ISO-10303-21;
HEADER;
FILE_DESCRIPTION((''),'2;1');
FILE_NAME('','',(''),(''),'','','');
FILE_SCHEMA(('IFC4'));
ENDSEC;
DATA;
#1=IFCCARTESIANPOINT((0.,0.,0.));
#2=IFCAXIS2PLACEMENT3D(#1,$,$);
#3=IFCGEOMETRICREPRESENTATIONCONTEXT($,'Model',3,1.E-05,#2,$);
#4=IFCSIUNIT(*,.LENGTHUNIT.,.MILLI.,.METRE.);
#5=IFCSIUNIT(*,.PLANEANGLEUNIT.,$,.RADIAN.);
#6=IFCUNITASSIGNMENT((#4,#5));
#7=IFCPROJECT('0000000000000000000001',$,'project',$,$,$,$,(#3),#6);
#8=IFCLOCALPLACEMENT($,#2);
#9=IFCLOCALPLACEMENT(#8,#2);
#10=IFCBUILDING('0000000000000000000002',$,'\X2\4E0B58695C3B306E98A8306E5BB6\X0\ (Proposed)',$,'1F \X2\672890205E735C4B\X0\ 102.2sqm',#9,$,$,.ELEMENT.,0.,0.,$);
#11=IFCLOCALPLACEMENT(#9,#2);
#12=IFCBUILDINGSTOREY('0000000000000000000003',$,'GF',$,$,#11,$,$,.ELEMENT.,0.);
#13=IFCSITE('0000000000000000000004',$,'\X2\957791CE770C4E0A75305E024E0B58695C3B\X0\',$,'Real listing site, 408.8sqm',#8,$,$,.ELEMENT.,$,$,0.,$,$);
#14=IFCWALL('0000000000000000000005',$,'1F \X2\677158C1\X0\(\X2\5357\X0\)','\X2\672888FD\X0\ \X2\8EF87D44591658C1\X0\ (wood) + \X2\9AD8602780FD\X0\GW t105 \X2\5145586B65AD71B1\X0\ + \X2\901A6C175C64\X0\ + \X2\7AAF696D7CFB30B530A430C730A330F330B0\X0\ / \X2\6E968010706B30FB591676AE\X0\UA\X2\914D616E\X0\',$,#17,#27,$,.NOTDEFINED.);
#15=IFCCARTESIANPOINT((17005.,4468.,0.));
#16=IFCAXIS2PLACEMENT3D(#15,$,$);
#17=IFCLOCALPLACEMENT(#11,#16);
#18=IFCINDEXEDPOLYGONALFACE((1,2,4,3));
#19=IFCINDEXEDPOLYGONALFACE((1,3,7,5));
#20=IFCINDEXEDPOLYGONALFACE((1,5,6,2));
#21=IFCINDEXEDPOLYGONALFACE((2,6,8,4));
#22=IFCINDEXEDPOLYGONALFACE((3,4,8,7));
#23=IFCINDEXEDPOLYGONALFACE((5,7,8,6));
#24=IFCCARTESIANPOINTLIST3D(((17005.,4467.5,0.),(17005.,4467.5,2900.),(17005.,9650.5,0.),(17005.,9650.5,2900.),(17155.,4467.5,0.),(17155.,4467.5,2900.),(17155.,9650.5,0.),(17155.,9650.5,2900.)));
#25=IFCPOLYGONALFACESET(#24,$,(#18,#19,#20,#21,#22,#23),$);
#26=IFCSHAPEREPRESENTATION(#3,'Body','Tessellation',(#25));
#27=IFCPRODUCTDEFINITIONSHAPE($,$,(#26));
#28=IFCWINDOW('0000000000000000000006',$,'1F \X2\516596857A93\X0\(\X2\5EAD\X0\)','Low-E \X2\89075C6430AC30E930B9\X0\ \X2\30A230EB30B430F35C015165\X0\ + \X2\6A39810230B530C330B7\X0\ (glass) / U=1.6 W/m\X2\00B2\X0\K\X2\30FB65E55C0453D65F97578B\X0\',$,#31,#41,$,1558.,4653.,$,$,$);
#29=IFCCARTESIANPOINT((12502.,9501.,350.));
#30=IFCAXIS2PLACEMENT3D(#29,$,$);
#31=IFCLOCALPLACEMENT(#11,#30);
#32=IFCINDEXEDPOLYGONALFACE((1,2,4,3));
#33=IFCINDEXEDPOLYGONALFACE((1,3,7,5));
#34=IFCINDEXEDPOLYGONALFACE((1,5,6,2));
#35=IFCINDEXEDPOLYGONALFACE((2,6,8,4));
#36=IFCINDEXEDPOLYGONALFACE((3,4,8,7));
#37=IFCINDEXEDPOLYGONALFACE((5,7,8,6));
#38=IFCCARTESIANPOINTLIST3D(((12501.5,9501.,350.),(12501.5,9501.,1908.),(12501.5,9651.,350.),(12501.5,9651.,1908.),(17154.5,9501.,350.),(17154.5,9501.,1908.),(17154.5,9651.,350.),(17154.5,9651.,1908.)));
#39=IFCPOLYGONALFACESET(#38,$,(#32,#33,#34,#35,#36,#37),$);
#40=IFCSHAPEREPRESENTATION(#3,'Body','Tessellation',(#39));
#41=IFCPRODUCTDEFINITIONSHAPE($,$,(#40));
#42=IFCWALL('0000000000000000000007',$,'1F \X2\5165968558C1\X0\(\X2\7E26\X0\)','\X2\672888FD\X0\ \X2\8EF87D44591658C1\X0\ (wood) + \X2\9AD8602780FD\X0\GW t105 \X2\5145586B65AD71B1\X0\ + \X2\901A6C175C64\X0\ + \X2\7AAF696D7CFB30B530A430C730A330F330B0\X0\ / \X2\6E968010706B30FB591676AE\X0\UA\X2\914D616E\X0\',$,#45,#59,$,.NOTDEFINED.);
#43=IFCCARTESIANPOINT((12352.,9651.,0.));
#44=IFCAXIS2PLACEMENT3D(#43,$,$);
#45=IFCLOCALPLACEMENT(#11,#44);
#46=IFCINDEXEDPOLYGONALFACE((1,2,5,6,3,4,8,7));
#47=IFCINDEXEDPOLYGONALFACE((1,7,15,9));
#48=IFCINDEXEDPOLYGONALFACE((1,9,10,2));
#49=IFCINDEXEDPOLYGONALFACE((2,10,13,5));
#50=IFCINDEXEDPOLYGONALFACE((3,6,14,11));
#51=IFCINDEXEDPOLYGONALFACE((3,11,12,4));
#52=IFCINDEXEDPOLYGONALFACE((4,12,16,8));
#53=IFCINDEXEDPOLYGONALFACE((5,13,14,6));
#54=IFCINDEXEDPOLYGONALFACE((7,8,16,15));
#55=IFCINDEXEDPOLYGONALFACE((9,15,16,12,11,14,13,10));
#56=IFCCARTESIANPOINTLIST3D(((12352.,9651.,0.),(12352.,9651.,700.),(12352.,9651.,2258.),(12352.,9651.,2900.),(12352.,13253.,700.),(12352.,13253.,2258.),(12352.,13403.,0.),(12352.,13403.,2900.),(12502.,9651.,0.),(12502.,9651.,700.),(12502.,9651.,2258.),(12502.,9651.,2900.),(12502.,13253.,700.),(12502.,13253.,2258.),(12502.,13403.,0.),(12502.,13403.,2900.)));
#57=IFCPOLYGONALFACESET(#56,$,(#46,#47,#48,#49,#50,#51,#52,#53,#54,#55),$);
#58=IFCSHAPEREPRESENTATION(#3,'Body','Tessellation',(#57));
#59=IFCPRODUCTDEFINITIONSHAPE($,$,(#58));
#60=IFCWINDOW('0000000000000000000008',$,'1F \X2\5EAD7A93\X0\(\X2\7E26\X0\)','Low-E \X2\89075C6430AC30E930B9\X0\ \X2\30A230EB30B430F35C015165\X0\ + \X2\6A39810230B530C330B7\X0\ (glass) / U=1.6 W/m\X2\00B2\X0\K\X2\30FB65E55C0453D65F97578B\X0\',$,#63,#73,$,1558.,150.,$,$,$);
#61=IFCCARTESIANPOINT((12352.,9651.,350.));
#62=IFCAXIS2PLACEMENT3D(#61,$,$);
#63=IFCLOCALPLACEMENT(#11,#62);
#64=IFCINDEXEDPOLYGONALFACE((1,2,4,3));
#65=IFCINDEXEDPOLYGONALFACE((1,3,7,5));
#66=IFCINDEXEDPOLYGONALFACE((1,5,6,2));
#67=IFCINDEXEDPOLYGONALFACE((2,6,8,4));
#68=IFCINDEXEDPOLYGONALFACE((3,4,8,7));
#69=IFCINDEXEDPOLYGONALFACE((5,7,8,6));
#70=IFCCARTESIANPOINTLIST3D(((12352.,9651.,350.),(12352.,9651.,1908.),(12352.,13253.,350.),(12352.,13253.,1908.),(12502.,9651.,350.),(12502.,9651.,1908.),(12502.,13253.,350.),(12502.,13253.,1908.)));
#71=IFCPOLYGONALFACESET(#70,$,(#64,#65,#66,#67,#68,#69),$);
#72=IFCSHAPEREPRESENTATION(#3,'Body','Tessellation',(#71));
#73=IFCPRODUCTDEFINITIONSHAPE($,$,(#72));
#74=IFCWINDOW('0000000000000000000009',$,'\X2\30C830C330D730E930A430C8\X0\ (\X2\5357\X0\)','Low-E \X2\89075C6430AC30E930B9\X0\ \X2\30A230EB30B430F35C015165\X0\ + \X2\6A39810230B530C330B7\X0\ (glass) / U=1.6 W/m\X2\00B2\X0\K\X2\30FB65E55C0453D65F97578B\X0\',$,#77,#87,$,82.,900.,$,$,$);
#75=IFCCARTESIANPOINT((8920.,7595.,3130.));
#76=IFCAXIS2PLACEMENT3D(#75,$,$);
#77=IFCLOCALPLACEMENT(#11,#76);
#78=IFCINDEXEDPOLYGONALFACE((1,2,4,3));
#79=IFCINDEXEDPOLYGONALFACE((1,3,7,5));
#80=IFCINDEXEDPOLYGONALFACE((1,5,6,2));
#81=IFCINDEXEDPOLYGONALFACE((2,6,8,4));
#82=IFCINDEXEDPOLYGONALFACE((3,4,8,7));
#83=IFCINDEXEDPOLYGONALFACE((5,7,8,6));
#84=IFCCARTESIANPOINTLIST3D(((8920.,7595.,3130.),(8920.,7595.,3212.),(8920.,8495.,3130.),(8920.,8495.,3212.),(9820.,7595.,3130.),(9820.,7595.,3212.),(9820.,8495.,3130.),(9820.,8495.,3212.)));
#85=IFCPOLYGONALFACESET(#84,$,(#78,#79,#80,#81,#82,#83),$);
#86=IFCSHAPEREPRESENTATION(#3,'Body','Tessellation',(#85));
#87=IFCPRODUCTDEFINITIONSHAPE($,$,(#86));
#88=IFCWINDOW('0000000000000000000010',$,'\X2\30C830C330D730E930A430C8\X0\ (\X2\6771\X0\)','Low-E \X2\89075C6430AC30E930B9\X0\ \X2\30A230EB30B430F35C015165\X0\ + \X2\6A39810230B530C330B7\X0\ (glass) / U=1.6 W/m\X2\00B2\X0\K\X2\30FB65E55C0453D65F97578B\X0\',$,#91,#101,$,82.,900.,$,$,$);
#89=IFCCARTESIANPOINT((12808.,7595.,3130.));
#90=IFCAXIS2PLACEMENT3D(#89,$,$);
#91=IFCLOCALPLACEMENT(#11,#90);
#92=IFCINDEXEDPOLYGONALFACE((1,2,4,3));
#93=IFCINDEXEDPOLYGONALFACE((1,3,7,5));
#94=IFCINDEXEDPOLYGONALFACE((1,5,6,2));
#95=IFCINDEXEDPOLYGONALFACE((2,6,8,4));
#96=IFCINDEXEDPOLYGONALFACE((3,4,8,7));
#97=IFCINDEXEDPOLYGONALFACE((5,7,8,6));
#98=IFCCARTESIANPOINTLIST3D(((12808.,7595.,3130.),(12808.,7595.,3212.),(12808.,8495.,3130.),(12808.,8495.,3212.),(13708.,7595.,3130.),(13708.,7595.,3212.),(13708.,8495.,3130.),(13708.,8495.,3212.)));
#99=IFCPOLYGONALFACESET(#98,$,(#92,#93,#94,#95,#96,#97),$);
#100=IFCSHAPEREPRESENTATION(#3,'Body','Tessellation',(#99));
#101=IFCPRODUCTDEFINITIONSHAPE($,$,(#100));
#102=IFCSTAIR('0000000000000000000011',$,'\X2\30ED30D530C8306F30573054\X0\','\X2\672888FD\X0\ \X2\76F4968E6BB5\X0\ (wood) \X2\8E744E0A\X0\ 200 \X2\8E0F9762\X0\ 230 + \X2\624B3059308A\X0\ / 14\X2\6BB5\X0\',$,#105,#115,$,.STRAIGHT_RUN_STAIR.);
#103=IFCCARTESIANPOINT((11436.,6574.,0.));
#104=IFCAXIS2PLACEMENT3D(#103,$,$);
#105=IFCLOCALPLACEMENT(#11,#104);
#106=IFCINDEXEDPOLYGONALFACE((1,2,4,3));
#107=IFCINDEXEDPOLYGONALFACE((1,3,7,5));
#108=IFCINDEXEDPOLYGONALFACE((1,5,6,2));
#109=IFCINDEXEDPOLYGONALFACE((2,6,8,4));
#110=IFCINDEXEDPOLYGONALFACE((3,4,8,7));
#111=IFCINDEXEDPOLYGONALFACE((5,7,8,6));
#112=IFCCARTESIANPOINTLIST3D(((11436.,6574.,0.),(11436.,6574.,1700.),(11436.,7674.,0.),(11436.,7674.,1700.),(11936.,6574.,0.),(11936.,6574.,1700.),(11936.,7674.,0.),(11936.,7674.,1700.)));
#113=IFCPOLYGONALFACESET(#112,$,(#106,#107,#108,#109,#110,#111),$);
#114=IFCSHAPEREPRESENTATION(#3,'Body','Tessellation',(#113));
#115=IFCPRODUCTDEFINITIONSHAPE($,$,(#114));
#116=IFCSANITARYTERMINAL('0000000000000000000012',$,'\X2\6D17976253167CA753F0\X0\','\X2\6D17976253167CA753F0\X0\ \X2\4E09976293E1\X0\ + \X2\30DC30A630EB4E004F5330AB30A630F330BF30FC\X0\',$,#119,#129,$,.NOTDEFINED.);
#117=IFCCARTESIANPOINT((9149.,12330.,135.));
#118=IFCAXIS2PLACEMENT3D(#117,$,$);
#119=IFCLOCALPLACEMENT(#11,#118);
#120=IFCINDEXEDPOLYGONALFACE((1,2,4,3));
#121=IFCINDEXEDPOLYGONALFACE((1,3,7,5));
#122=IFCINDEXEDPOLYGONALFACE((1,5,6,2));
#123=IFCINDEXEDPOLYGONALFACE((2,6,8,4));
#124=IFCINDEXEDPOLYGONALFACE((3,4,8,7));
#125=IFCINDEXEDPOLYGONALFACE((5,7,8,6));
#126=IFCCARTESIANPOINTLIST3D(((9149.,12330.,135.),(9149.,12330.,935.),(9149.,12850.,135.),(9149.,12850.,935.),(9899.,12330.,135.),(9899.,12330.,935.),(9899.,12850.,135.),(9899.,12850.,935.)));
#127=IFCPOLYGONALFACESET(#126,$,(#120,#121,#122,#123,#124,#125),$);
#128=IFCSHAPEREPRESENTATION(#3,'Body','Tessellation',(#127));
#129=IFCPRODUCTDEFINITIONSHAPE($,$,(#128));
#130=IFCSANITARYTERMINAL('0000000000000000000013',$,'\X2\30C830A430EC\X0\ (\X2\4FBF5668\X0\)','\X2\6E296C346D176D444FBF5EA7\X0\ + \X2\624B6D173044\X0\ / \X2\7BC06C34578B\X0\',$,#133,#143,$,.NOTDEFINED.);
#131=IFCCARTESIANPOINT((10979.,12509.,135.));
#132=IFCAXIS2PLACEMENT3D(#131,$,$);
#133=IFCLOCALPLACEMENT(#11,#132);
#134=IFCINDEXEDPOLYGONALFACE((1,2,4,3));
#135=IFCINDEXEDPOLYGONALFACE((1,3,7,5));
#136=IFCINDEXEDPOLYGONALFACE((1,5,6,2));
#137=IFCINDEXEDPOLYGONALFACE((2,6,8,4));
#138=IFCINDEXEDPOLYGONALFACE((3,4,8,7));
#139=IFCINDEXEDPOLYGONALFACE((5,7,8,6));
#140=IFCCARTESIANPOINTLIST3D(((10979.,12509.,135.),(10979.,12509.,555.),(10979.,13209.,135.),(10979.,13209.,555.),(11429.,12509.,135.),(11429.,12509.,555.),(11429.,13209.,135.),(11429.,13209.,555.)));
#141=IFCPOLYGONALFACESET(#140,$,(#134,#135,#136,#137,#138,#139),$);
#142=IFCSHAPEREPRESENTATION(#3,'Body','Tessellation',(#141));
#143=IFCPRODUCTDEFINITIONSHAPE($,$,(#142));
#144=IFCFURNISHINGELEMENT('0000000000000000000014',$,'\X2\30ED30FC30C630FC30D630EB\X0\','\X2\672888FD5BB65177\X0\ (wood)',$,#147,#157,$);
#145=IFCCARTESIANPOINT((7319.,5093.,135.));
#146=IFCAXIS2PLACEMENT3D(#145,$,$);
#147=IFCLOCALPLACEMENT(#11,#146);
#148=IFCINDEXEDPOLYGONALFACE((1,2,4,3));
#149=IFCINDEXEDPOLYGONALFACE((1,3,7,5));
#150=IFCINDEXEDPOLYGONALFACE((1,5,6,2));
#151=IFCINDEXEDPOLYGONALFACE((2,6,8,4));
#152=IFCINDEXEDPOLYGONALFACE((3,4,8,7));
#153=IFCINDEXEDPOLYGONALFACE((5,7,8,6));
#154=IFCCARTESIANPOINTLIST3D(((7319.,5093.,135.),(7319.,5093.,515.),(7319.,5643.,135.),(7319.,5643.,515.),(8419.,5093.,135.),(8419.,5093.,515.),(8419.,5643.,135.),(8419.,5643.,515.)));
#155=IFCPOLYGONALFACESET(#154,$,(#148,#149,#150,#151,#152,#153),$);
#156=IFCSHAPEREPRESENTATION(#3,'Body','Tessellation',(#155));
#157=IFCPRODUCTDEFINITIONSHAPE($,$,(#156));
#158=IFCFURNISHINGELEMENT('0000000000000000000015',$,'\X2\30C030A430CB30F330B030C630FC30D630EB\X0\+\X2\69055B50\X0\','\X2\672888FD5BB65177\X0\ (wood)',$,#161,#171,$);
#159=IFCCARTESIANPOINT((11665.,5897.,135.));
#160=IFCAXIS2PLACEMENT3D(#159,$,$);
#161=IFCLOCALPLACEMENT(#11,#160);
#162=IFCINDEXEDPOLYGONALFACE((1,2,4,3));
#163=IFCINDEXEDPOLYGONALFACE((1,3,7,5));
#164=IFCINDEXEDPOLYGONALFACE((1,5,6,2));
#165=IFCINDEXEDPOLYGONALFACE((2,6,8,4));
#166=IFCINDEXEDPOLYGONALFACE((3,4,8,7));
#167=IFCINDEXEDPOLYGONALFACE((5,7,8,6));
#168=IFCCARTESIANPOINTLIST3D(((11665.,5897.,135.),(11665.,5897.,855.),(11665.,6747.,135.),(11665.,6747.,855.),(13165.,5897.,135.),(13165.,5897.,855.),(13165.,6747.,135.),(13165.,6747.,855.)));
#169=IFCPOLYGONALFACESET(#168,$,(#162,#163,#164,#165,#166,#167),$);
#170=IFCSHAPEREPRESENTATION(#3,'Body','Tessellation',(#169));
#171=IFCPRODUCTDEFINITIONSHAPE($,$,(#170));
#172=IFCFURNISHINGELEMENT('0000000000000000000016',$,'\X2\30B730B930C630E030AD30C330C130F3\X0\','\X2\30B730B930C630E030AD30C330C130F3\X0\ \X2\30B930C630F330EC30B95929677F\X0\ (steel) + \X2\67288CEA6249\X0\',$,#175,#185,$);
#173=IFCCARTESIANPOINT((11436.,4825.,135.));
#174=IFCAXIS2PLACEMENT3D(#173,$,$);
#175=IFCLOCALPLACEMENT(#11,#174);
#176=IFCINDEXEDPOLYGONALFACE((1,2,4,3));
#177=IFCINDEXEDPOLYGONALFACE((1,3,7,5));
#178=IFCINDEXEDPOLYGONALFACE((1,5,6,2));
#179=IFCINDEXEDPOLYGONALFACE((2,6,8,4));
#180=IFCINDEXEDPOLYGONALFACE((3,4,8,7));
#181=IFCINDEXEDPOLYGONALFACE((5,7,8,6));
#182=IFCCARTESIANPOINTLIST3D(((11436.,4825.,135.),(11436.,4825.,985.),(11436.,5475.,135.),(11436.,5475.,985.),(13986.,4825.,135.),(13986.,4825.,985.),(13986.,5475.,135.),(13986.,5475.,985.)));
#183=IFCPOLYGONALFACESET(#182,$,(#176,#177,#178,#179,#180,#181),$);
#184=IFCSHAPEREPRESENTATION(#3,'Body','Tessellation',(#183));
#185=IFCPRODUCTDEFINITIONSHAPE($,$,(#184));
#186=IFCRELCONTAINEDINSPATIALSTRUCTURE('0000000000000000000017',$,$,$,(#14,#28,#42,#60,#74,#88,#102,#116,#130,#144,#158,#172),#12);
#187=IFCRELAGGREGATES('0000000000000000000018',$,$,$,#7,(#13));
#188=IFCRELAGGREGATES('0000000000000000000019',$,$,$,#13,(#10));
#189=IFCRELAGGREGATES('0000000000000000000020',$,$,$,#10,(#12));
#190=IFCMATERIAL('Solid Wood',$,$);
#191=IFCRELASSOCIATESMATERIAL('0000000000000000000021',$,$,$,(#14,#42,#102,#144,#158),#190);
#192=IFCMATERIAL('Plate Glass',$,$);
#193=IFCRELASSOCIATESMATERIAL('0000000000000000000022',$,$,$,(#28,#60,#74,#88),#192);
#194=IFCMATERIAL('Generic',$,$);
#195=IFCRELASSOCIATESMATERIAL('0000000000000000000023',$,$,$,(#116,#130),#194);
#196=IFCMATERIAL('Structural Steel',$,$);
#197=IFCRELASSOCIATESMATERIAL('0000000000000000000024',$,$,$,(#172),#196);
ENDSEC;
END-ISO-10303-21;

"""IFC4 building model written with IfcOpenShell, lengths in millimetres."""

from ifc_helpers import new_model, si_unit, frame, frame_2d, origin, place, context, project, spatial, rectangle, extrude, material, element, fill, save


model = new_model("IFC4")

# Units and contexts
model_context = context("Model", 3, precision=1e-05, world=origin())
ifc_project = project(units=[si_unit("LENGTHUNIT", "METRE", prefix="MILLI"), si_unit("PLANEANGLEUNIT", "RADIAN")], contexts=[model_context])

# Site, building, storey
site_placement = place(None, origin())
site = spatial("IfcSite", under=ifc_project, at=site_placement, Name="長野県上田市下塩尻", ObjectType="Real listing site, 408.8sqm", CompositionType="ELEMENT", RefElevation=0.0)
building_placement = place(site_placement, origin())
building = spatial("IfcBuilding", under=site, at=building_placement, Name="下塩尻の風の家 (Proposed)", ObjectType="1F 木造平屋 102.2sqm", CompositionType="ELEMENT", ElevationOfRefHeight=0.0, ElevationOfTerrain=0.0)
storey_placement = place(building_placement, origin())
storey = spatial("IfcBuildingStorey", under=building, at=storey_placement, Name="GF", CompositionType="ELEMENT", Elevation=0.0)

# Shared definitions
ifc_material_1 = material(Name="Solid Wood")

# Wall, opening, window
wall_1_placement = place(storey_placement, frame((17005.0, 4468.0, 0.0)))
wall_1 = element("IfcWall", 1, at=wall_1_placement, inside=storey, material=ifc_material_1, Name="1F 東壁(南)", Description="木製 軸組外壁 (wood) + 高性能GW t105 充填断熱 + 通気層 + 窯業系サイディング / 準耐火・外皮UA配慮", PredefinedType="NOTDEFINED", context=model_context, shape_type="SweptSolid", body=[
    extrude(rectangle(XDim=150.0, YDim=5183.0, at=frame_2d((75.0, 2591.0))), frame((17005.0, 4468.0, 0.0)), (0.0, 0.0, 1.0), 2900.0),
])
opening_1_placement = place(storey_placement, frame((12502.0, 9501.0, 350.0)))
opening_1 = element("IfcOpeningElement", 2, at=opening_1_placement, cuts=wall_1, PredefinedType="NOTDEFINED", context=model_context, shape_type="SweptSolid", body=[
    extrude(rectangle(XDim=4653.0, YDim=150.0, at=frame_2d((2326.0, 75.0))), frame((12502.0, 9501.0, 350.0)), (0.0, 0.0, 1.0), 1558.0),
])
ifc_material_2 = material(Name="Plate Glass")
window_1_placement = place(storey_placement, frame((12502.0, 9501.0, 350.0)))
window_1 = element("IfcWindow", 3, at=window_1_placement, inside=storey, material=ifc_material_2, Name="1F 入隅窓(庭)", Description="Low-E 複層ガラス アルゴン封入 + 樹脂サッシ (glass) / U=1.6 W/m²K・日射取得型", OverallHeight=1558.0, OverallWidth=4653.0, context=model_context, shape_type="SweptSolid", body=[
    extrude(rectangle(XDim=4653.0, YDim=150.0, at=frame_2d((2326.0, 75.0))), frame((12502.0, 9501.0, 350.0)), (0.0, 0.0, 1.0), 1558.0),
])
fill(opening_1, window_1)

# Wall, opening, window
wall_2_placement = place(storey_placement, frame((12352.0, 9651.0, 0.0)))
wall_2 = element("IfcWall", 4, at=wall_2_placement, inside=storey, material=ifc_material_1, Name="1F 入隅壁(縦)", Description="木製 軸組外壁 (wood) + 高性能GW t105 充填断熱 + 通気層 + 窯業系サイディング / 準耐火・外皮UA配慮", PredefinedType="NOTDEFINED", context=model_context, shape_type="SweptSolid", body=[
    extrude(rectangle(XDim=150.0, YDim=3752.0, at=frame_2d((75.0, 1876.0))), frame((12352.0, 9651.0, 0.0)), (0.0, 0.0, 1.0), 2900.0),
])
opening_2_placement = place(storey_placement, frame((12352.0, 9651.0, 350.0)))
opening_2 = element("IfcOpeningElement", 5, at=opening_2_placement, cuts=wall_2, PredefinedType="NOTDEFINED", context=model_context, shape_type="SweptSolid", body=[
    extrude(rectangle(XDim=150.0, YDim=3602.0, at=frame_2d((75.0, 1801.0))), frame((12352.0, 9651.0, 350.0)), (0.0, 0.0, 1.0), 1558.0),
])
window_2_placement = place(storey_placement, frame((12352.0, 9651.0, 350.0)))
window_2 = element("IfcWindow", 6, at=window_2_placement, inside=storey, material=ifc_material_2, Name="1F 庭窓(縦)", Description="Low-E 複層ガラス アルゴン封入 + 樹脂サッシ (glass) / U=1.6 W/m²K・日射取得型", OverallHeight=1558.0, OverallWidth=150.0, context=model_context, shape_type="SweptSolid", body=[
    extrude(rectangle(XDim=150.0, YDim=3602.0, at=frame_2d((75.0, 1801.0))), frame((12352.0, 9651.0, 350.0)), (0.0, 0.0, 1.0), 1558.0),
])
fill(opening_2, window_2)

# Windows
window_3_placement = place(storey_placement, frame((8920.0, 7595.0, 3130.0)))
element("IfcWindow", 7, at=window_3_placement, inside=storey, material=ifc_material_2, Name="トップライト (南)", Description="Low-E 複層ガラス アルゴン封入 + 樹脂サッシ (glass) / U=1.6 W/m²K・日射取得型", OverallHeight=82.0, OverallWidth=900.0, context=model_context, shape_type="SweptSolid", body=[
    extrude(rectangle(XDim=900.0, YDim=900.0, at=frame_2d((450.0, 450.0))), frame((8920.0, 7595.0, 3130.0)), (0.0, 0.0, 1.0), 82.0),
])
window_4_placement = place(storey_placement, frame((12808.0, 7595.0, 3130.0)))
element("IfcWindow", 8, at=window_4_placement, inside=storey, material=ifc_material_2, Name="トップライト (東)", Description="Low-E 複層ガラス アルゴン封入 + 樹脂サッシ (glass) / U=1.6 W/m²K・日射取得型", OverallHeight=82.0, OverallWidth=900.0, context=model_context, shape_type="SweptSolid", body=[
    extrude(rectangle(XDim=900.0, YDim=900.0, at=frame_2d((450.0, 450.0))), frame((12808.0, 7595.0, 3130.0)), (0.0, 0.0, 1.0), 82.0),
])

# Stair
stair_placement = place(storey_placement, frame((11436.0, 6574.0, 0.0)))
element("IfcStair", 9, at=stair_placement, inside=storey, material=ifc_material_1, Name="ロフトはしご", Description="木製 直階段 (wood) 蹴上 200 踏面 230 + 手すり / 14段", PredefinedType="STRAIGHT_RUN_STAIR", context=model_context, shape_type="SweptSolid", body=[
    extrude(rectangle(XDim=500.0, YDim=1100.0, at=frame_2d((250.0, 550.0))), frame((11436.0, 6574.0, 0.0)), (0.0, 0.0, 1.0), 1700.0),
])

# Sanitary terminals
ifc_material_3 = material(Name="Generic")
sanitary_terminal_1_placement = place(storey_placement, frame((9149.0, 12330.0, 135.0)))
element("IfcSanitaryTerminal", 10, at=sanitary_terminal_1_placement, inside=storey, material=ifc_material_3, Name="洗面化粧台", Description="洗面化粧台 三面鏡 + ボウル一体カウンター", PredefinedType="NOTDEFINED", context=model_context, shape_type="SweptSolid", body=[
    extrude(rectangle(XDim=750.0, YDim=520.0, at=frame_2d((375.0, 260.0))), frame((9149.0, 12330.0, 135.0)), (0.0, 0.0, 1.0), 800.0),
])
sanitary_terminal_2_placement = place(storey_placement, frame((10979.0, 12509.0, 135.0)))
element("IfcSanitaryTerminal", 11, at=sanitary_terminal_2_placement, inside=storey, material=ifc_material_3, Name="トイレ (便器)", Description="温水洗浄便座 + 手洗い / 節水型", PredefinedType="NOTDEFINED", context=model_context, shape_type="SweptSolid", body=[
    extrude(rectangle(XDim=450.0, YDim=700.0, at=frame_2d((225.0, 350.0))), frame((10979.0, 12509.0, 135.0)), (0.0, 0.0, 1.0), 420.0),
])

# Furnishing elements
furnishing_1_placement = place(storey_placement, frame((7319.0, 5093.0, 135.0)))
element("IfcFurnishingElement", 12, at=furnishing_1_placement, inside=storey, material=ifc_material_1, Name="ローテーブル", Description="木製家具 (wood)", context=model_context, shape_type="SweptSolid", body=[
    extrude(rectangle(XDim=1100.0, YDim=550.0, at=frame_2d((550.0, 275.0))), frame((7319.0, 5093.0, 135.0)), (0.0, 0.0, 1.0), 380.0),
])
furnishing_2_placement = place(storey_placement, frame((11665.0, 5897.0, 135.0)))
element("IfcFurnishingElement", 13, at=furnishing_2_placement, inside=storey, material=ifc_material_1, Name="ダイニングテーブル+椅子", Description="木製家具 (wood)", context=model_context, shape_type="SweptSolid", body=[
    extrude(rectangle(XDim=1500.0, YDim=850.0, at=frame_2d((750.0, 425.0))), frame((11665.0, 5897.0, 135.0)), (0.0, 0.0, 1.0), 720.0),
])
ifc_material_4 = material(Name="Structural Steel")
furnishing_3_placement = place(storey_placement, frame((11436.0, 4825.0, 135.0)))
element("IfcFurnishingElement", 14, at=furnishing_3_placement, inside=storey, material=ifc_material_4, Name="システムキッチン", Description="システムキッチン ステンレス天板 (steel) + 木質扉", context=model_context, shape_type="SweptSolid", body=[
    extrude(rectangle(XDim=2550.0, YDim=650.0, at=frame_2d((1275.0, 325.0))), frame((11436.0, 4825.0, 135.0)), (0.0, 0.0, 1.0), 850.0),
])

save(model, "model.ifc")
